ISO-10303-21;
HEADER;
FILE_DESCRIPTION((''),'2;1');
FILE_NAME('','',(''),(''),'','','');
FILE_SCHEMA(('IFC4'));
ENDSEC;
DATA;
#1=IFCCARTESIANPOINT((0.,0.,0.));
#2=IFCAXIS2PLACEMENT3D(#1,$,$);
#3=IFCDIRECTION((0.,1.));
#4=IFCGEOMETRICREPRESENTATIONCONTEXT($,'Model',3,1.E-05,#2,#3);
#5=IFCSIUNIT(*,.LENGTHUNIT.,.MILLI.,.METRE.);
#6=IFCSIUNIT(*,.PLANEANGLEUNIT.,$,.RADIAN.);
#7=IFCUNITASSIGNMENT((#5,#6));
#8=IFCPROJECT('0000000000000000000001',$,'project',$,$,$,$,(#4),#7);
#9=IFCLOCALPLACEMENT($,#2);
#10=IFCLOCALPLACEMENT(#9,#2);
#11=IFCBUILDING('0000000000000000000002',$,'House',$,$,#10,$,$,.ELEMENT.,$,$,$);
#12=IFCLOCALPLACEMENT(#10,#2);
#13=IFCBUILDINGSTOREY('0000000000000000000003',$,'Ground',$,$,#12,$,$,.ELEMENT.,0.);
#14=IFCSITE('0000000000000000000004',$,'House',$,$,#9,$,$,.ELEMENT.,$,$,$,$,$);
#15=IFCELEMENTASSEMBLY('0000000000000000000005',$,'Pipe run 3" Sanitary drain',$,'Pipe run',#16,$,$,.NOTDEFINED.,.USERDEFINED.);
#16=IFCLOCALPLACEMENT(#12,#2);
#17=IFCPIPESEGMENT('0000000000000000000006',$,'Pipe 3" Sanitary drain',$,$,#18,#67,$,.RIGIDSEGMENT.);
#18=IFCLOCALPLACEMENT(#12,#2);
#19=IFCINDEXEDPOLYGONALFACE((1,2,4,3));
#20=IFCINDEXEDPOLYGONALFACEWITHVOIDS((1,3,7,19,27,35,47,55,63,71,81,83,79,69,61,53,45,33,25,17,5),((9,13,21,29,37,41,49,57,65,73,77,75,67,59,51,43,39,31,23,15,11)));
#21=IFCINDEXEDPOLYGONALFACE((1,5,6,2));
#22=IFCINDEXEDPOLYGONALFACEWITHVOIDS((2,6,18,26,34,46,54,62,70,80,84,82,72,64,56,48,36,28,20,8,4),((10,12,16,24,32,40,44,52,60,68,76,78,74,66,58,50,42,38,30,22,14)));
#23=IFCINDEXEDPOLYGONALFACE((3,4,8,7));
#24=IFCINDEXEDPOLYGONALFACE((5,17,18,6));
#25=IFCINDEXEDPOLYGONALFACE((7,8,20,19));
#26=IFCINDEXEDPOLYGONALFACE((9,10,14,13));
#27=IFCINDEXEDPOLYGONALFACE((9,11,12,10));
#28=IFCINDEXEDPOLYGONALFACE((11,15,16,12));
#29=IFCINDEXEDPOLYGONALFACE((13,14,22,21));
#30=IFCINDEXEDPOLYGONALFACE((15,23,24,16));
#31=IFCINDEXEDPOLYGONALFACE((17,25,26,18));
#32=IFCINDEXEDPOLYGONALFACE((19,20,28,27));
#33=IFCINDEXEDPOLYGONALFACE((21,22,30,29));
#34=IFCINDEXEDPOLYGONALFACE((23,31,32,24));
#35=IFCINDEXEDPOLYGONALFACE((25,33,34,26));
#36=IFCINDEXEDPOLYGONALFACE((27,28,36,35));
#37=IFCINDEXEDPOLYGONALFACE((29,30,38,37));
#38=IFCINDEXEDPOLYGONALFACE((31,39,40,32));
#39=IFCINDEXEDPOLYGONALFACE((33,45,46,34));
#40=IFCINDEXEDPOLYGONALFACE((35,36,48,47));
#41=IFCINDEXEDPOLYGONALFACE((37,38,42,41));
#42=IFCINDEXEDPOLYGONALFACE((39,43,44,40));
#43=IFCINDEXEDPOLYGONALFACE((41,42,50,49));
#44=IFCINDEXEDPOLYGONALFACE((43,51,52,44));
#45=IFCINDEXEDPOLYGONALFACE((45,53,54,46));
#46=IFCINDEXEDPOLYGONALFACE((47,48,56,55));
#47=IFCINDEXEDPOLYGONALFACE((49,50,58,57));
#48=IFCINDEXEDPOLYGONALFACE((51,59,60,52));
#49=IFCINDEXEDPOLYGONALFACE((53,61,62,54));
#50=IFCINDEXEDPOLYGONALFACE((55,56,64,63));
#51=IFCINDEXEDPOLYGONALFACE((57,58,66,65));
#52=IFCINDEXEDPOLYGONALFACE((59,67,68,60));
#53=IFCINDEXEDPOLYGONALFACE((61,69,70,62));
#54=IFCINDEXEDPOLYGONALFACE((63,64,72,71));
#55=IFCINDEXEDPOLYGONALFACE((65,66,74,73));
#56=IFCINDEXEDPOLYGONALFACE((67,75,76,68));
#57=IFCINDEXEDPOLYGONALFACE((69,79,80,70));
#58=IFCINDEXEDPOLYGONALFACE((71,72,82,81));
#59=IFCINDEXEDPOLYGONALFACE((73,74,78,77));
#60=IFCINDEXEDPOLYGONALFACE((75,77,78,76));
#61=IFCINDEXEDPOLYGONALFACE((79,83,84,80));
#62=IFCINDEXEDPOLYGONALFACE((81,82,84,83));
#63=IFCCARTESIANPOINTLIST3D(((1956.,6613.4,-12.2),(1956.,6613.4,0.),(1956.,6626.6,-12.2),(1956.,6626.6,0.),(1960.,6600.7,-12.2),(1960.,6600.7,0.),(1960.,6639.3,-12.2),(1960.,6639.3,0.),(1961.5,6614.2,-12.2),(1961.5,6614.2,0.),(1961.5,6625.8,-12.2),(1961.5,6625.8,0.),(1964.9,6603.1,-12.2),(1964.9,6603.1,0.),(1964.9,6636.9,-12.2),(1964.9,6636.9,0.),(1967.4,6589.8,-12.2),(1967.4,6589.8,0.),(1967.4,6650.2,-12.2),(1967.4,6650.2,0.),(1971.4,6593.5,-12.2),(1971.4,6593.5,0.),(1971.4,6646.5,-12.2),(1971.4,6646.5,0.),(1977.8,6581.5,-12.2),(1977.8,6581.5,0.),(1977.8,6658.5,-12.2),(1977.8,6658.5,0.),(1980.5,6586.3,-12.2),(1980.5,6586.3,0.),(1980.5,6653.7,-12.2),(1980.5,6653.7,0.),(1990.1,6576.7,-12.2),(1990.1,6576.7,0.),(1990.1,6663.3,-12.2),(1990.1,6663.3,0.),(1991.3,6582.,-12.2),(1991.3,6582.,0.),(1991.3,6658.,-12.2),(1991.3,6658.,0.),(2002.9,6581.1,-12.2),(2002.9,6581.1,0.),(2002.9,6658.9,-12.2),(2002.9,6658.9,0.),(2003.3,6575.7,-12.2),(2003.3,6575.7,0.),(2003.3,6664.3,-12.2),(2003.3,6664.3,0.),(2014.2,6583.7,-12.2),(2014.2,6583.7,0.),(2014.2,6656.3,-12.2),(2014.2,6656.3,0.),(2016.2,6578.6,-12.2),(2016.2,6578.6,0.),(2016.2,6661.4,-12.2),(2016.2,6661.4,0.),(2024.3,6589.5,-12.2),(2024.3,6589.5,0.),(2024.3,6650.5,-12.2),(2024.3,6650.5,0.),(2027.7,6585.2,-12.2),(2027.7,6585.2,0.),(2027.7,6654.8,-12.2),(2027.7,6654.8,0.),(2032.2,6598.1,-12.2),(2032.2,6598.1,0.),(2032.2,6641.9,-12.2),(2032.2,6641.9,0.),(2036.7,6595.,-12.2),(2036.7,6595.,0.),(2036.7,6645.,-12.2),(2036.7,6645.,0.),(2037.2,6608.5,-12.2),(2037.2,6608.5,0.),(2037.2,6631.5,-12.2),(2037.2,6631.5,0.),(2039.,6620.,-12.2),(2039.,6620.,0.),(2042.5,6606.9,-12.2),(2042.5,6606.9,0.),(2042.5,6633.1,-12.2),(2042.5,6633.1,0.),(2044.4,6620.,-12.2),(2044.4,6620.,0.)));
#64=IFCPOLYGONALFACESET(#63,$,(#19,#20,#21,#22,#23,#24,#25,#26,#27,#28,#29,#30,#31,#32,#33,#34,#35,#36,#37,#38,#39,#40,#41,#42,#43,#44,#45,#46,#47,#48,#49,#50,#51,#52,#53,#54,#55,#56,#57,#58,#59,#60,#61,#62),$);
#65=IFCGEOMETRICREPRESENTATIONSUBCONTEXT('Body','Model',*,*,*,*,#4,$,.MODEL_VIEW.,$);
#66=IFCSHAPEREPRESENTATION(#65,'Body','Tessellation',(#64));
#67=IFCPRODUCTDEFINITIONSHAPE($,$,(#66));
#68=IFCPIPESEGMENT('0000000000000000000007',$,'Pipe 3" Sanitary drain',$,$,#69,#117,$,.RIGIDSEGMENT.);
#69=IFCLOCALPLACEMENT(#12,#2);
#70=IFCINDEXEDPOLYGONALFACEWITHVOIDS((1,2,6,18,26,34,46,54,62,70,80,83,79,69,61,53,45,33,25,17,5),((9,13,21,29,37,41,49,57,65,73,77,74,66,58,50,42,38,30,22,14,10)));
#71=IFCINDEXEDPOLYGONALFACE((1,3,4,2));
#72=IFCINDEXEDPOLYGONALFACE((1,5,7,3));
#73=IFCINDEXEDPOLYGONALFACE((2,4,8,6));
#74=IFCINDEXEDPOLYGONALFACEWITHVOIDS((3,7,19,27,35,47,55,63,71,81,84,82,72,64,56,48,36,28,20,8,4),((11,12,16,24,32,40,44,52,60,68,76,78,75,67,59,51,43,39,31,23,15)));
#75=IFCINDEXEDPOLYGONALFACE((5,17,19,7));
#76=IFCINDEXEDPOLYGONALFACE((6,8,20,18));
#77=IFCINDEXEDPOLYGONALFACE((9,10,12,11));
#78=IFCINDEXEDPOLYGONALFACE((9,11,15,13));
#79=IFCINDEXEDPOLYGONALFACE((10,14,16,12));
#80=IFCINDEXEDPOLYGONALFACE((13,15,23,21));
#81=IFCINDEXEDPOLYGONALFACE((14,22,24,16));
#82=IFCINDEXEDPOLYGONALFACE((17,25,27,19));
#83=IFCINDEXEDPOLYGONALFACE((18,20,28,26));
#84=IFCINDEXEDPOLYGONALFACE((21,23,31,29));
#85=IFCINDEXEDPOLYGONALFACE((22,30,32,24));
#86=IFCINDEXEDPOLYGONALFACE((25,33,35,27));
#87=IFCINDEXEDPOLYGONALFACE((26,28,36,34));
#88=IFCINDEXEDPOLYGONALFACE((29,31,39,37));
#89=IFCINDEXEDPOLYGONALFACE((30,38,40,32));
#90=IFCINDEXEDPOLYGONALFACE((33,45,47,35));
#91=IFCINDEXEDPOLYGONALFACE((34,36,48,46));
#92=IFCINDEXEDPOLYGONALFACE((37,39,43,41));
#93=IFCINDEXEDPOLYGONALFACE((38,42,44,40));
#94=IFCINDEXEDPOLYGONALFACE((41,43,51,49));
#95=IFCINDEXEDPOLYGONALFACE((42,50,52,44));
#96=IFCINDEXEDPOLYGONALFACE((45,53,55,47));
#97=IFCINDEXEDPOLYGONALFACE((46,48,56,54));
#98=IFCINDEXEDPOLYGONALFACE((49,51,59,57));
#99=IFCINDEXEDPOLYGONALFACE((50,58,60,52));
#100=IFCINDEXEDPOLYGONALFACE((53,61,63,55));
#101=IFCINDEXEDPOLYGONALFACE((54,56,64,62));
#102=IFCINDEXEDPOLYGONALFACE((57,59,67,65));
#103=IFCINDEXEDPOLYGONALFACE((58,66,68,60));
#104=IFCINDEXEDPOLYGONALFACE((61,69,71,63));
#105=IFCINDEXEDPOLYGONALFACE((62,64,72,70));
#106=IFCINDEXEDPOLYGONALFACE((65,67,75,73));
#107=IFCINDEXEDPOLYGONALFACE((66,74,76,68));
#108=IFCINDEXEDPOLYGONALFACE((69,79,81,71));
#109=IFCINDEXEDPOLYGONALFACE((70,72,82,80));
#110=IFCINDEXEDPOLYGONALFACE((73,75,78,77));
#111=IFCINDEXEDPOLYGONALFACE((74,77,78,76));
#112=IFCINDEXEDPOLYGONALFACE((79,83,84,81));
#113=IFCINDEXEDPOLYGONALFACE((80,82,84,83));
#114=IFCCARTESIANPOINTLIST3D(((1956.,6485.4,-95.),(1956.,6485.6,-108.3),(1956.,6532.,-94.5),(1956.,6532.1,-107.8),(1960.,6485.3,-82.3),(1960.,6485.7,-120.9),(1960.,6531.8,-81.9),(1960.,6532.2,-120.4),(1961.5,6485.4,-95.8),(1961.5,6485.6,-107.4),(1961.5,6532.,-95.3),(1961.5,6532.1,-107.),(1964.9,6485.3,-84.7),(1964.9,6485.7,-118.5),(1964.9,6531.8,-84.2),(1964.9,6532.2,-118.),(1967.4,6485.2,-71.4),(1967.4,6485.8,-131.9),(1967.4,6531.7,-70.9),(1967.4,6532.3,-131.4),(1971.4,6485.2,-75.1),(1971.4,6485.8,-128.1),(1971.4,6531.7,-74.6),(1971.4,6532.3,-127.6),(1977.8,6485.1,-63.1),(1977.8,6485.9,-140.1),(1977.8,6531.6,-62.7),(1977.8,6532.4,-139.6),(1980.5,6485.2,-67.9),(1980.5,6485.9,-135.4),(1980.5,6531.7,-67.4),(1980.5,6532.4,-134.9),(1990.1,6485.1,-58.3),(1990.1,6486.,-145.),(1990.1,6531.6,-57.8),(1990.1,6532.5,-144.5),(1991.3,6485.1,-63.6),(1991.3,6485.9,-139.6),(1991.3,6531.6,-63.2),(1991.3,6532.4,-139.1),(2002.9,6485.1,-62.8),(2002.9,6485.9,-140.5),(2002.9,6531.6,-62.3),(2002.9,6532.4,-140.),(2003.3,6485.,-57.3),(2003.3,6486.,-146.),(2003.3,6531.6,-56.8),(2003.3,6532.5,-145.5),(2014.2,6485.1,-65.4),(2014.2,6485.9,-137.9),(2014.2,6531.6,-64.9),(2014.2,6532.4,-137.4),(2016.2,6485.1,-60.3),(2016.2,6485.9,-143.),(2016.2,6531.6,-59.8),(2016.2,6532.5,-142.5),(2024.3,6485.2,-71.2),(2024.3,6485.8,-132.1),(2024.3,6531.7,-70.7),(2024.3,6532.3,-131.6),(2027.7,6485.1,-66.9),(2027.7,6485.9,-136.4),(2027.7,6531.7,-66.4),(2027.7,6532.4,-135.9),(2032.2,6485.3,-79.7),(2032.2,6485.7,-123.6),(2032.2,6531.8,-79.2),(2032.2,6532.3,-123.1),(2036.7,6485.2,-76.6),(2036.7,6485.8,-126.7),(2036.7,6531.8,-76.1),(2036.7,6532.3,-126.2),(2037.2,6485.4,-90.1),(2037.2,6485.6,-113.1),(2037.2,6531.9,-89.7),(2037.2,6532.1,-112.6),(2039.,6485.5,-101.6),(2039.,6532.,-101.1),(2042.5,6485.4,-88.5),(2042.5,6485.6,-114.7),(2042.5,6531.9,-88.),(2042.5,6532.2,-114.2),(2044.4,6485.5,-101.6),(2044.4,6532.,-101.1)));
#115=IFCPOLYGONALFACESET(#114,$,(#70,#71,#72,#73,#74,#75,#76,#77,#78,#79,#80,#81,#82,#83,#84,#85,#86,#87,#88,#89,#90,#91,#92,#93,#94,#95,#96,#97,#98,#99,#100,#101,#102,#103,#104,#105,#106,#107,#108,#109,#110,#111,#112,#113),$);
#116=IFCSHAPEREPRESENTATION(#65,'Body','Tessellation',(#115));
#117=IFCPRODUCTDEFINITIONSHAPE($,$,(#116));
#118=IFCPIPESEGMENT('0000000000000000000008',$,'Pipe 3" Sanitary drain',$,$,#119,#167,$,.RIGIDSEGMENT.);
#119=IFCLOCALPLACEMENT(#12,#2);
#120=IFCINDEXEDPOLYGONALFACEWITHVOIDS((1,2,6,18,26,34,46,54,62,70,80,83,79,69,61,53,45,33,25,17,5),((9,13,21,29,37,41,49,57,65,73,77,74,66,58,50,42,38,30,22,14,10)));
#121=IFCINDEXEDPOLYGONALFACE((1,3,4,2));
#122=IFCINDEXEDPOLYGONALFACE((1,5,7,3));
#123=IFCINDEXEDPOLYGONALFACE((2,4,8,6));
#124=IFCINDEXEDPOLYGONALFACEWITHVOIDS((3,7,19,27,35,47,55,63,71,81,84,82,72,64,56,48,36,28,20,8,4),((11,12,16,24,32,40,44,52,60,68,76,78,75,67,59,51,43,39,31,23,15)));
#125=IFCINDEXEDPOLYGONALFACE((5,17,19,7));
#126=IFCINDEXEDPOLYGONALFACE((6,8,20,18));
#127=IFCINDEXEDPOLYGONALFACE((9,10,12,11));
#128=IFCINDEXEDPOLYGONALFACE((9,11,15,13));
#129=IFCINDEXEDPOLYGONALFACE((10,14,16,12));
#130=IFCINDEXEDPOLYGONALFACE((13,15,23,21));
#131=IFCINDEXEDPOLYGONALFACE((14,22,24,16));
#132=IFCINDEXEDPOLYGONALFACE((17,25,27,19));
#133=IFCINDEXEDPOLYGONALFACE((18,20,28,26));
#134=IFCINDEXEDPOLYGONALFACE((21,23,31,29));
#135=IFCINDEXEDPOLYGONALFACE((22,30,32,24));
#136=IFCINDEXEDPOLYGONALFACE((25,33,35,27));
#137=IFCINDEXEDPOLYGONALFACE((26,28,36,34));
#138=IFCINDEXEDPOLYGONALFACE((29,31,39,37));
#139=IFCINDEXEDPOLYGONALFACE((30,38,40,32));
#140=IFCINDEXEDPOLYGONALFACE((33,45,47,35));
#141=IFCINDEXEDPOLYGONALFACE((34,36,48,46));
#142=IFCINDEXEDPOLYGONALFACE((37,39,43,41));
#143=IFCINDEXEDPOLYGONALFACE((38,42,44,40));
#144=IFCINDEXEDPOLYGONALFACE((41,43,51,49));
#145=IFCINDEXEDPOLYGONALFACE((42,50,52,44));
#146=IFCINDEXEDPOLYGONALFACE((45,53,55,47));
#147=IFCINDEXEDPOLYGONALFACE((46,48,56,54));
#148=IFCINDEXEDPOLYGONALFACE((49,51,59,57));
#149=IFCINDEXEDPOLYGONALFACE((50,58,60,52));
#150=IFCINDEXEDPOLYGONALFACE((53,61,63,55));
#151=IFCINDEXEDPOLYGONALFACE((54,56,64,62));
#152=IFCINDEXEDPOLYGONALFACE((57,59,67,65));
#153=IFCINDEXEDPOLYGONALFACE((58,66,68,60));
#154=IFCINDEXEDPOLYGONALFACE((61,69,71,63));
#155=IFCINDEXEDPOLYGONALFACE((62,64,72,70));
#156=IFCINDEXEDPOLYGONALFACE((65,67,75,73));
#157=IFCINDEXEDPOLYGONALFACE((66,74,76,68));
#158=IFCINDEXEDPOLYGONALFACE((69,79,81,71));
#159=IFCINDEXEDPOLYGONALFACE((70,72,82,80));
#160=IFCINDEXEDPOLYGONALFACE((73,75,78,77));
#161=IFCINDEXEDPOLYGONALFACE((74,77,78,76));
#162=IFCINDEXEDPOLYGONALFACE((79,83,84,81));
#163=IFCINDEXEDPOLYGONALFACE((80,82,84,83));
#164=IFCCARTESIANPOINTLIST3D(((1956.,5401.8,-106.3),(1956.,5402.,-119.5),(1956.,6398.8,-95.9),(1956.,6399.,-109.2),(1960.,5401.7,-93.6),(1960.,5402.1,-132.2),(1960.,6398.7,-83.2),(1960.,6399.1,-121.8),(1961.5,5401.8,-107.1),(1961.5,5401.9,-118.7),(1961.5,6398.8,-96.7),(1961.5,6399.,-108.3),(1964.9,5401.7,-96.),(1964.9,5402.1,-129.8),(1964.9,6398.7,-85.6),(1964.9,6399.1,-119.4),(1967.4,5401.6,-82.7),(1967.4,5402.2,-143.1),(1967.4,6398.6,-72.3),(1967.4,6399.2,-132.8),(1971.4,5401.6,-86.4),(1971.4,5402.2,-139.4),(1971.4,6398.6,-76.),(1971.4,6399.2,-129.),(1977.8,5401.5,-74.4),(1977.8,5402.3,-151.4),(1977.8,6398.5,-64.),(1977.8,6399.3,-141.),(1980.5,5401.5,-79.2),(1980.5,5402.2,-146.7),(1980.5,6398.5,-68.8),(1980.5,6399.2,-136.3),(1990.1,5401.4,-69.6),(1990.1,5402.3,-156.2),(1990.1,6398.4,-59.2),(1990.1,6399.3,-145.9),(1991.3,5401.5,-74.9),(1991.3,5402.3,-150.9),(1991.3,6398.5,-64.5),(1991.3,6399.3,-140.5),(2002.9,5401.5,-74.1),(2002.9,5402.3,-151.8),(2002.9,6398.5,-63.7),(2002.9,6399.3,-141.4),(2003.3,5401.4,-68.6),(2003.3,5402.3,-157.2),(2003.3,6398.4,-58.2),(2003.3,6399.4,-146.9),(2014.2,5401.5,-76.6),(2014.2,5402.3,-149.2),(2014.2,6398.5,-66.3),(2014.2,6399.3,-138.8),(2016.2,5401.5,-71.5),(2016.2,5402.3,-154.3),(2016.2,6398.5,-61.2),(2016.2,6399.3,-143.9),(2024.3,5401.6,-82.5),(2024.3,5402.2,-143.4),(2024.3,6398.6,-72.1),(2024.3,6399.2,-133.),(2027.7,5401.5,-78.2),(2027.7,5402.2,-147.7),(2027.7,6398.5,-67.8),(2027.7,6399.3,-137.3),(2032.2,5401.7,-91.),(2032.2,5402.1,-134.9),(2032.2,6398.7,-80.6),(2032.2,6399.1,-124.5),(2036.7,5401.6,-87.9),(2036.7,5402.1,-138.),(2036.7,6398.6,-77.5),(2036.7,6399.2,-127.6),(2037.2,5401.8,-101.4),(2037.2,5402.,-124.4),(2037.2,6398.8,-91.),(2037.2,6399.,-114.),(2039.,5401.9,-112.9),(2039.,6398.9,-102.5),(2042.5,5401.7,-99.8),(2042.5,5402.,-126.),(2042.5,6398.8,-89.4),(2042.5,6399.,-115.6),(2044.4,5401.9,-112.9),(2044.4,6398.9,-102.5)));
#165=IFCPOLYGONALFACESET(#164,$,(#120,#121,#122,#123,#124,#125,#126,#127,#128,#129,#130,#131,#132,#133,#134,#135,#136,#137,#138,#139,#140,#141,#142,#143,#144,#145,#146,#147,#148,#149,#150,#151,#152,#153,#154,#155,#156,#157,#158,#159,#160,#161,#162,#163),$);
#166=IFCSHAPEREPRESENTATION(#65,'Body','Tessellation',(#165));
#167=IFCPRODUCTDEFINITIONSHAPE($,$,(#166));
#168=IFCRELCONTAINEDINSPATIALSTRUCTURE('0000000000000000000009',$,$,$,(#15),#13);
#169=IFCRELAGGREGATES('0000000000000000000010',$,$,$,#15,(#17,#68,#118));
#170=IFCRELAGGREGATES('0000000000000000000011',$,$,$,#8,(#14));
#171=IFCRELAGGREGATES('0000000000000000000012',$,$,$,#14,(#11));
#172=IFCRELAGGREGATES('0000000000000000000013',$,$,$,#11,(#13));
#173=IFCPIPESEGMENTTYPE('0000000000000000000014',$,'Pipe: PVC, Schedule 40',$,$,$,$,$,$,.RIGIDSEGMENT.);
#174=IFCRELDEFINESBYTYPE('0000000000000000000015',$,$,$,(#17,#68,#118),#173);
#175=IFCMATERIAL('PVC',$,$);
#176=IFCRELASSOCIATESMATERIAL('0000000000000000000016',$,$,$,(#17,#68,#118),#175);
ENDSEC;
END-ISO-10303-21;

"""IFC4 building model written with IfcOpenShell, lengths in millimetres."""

from ifc_helpers import new_model, si_unit, direction, frame, origin, origin_with_axes, origin_2d, place, context, subcontext, project, spatial, hollow_circle, extrude, material, type_object, element, aggregate, save


model = new_model("IFC4")

# Units and contexts
model_context = context("Model", 3, precision=1e-05, world=origin(), true_north=direction((0.0, 1.0)))
body_context = subcontext(model_context, "Body", "Model", "MODEL_VIEW")
ifc_project = project(units=[si_unit("LENGTHUNIT", "METRE", prefix="MILLI"), si_unit("PLANEANGLEUNIT", "RADIAN")], contexts=[model_context])

# Site, building, storey
site_placement = place(None, origin())
site = spatial("IfcSite", under=ifc_project, at=site_placement, Name="House", CompositionType="ELEMENT")
building_placement = place(site_placement, origin())
building = spatial("IfcBuilding", under=site, at=building_placement, Name="House", CompositionType="ELEMENT")
storey_placement = place(building_placement, origin())
storey = spatial("IfcBuildingStorey", under=building, at=storey_placement, Name="Ground", CompositionType="ELEMENT", Elevation=0.0)

# Shared definitions
ifc_material = material(Name="PVC")
pipe_segment_type = type_object("IfcPipeSegmentType", Name="Pipe: PVC, Schedule 40", PredefinedType="RIGIDSEGMENT")

# Element assembly, pipe segments
assembly_1_placement = place(storey_placement, origin_with_axes())
assembly_1 = element("IfcElementAssembly", 1, at=assembly_1_placement, inside=storey, Name="Pipe run 3\" Sanitary drain", ObjectType="Pipe run", AssemblyPlace="NOTDEFINED", PredefinedType="USERDEFINED")
pipe_segment_1_placement = place(storey_placement, origin_with_axes())
pipe_segment_1 = element("IfcPipeSegment", 2, at=pipe_segment_1_placement, type_object=pipe_segment_type, material=ifc_material, Name="Pipe 3\" Sanitary drain", PredefinedType="RIGIDSEGMENT", context=body_context, shape_type="SweptSolid", body=[
    extrude(hollow_circle(Radius=44.5, WallThickness=5.5, at=origin_2d()), frame((2000.0, 6620.0, 0.0), z_axis=(0.0, 0.0, -1.0), x_axis=(1.0, 0.0, 0.0)), (0.0, 0.0, 1.0), 12.2),
])
pipe_segment_2_placement = place(storey_placement, origin_with_axes())
pipe_segment_2 = element("IfcPipeSegment", 3, at=pipe_segment_2_placement, type_object=pipe_segment_type, material=ifc_material, Name="Pipe 3\" Sanitary drain", PredefinedType="RIGIDSEGMENT", context=body_context, shape_type="SweptSolid", body=[
    extrude(hollow_circle(Radius=44.5, WallThickness=5.5, at=origin_2d()), frame((2000.0, 6532.0, -101.1), z_axis=(0.0, -0.999946, -0.010416), x_axis=(1.0, 0.0, 0.0)), (0.0, 0.0, 1.0), 46.5),
])
pipe_segment_3_placement = place(storey_placement, origin_with_axes())
pipe_segment_3 = element("IfcPipeSegment", 4, at=pipe_segment_3_placement, type_object=pipe_segment_type, material=ifc_material, Name="Pipe 3\" Sanitary drain", PredefinedType="RIGIDSEGMENT", context=body_context, shape_type="SweptSolid", body=[
    extrude(hollow_circle(Radius=44.5, WallThickness=5.5, at=origin_2d()), frame((2000.0, 6398.9, -102.5), z_axis=(0.0, -0.999946, -0.010416), x_axis=(1.0, 0.0, 0.0)), (0.0, 0.0, 1.0), 997.1),
])

aggregate(assembly_1, [pipe_segment_1, pipe_segment_2, pipe_segment_3])

save(model, "model.ifc")
